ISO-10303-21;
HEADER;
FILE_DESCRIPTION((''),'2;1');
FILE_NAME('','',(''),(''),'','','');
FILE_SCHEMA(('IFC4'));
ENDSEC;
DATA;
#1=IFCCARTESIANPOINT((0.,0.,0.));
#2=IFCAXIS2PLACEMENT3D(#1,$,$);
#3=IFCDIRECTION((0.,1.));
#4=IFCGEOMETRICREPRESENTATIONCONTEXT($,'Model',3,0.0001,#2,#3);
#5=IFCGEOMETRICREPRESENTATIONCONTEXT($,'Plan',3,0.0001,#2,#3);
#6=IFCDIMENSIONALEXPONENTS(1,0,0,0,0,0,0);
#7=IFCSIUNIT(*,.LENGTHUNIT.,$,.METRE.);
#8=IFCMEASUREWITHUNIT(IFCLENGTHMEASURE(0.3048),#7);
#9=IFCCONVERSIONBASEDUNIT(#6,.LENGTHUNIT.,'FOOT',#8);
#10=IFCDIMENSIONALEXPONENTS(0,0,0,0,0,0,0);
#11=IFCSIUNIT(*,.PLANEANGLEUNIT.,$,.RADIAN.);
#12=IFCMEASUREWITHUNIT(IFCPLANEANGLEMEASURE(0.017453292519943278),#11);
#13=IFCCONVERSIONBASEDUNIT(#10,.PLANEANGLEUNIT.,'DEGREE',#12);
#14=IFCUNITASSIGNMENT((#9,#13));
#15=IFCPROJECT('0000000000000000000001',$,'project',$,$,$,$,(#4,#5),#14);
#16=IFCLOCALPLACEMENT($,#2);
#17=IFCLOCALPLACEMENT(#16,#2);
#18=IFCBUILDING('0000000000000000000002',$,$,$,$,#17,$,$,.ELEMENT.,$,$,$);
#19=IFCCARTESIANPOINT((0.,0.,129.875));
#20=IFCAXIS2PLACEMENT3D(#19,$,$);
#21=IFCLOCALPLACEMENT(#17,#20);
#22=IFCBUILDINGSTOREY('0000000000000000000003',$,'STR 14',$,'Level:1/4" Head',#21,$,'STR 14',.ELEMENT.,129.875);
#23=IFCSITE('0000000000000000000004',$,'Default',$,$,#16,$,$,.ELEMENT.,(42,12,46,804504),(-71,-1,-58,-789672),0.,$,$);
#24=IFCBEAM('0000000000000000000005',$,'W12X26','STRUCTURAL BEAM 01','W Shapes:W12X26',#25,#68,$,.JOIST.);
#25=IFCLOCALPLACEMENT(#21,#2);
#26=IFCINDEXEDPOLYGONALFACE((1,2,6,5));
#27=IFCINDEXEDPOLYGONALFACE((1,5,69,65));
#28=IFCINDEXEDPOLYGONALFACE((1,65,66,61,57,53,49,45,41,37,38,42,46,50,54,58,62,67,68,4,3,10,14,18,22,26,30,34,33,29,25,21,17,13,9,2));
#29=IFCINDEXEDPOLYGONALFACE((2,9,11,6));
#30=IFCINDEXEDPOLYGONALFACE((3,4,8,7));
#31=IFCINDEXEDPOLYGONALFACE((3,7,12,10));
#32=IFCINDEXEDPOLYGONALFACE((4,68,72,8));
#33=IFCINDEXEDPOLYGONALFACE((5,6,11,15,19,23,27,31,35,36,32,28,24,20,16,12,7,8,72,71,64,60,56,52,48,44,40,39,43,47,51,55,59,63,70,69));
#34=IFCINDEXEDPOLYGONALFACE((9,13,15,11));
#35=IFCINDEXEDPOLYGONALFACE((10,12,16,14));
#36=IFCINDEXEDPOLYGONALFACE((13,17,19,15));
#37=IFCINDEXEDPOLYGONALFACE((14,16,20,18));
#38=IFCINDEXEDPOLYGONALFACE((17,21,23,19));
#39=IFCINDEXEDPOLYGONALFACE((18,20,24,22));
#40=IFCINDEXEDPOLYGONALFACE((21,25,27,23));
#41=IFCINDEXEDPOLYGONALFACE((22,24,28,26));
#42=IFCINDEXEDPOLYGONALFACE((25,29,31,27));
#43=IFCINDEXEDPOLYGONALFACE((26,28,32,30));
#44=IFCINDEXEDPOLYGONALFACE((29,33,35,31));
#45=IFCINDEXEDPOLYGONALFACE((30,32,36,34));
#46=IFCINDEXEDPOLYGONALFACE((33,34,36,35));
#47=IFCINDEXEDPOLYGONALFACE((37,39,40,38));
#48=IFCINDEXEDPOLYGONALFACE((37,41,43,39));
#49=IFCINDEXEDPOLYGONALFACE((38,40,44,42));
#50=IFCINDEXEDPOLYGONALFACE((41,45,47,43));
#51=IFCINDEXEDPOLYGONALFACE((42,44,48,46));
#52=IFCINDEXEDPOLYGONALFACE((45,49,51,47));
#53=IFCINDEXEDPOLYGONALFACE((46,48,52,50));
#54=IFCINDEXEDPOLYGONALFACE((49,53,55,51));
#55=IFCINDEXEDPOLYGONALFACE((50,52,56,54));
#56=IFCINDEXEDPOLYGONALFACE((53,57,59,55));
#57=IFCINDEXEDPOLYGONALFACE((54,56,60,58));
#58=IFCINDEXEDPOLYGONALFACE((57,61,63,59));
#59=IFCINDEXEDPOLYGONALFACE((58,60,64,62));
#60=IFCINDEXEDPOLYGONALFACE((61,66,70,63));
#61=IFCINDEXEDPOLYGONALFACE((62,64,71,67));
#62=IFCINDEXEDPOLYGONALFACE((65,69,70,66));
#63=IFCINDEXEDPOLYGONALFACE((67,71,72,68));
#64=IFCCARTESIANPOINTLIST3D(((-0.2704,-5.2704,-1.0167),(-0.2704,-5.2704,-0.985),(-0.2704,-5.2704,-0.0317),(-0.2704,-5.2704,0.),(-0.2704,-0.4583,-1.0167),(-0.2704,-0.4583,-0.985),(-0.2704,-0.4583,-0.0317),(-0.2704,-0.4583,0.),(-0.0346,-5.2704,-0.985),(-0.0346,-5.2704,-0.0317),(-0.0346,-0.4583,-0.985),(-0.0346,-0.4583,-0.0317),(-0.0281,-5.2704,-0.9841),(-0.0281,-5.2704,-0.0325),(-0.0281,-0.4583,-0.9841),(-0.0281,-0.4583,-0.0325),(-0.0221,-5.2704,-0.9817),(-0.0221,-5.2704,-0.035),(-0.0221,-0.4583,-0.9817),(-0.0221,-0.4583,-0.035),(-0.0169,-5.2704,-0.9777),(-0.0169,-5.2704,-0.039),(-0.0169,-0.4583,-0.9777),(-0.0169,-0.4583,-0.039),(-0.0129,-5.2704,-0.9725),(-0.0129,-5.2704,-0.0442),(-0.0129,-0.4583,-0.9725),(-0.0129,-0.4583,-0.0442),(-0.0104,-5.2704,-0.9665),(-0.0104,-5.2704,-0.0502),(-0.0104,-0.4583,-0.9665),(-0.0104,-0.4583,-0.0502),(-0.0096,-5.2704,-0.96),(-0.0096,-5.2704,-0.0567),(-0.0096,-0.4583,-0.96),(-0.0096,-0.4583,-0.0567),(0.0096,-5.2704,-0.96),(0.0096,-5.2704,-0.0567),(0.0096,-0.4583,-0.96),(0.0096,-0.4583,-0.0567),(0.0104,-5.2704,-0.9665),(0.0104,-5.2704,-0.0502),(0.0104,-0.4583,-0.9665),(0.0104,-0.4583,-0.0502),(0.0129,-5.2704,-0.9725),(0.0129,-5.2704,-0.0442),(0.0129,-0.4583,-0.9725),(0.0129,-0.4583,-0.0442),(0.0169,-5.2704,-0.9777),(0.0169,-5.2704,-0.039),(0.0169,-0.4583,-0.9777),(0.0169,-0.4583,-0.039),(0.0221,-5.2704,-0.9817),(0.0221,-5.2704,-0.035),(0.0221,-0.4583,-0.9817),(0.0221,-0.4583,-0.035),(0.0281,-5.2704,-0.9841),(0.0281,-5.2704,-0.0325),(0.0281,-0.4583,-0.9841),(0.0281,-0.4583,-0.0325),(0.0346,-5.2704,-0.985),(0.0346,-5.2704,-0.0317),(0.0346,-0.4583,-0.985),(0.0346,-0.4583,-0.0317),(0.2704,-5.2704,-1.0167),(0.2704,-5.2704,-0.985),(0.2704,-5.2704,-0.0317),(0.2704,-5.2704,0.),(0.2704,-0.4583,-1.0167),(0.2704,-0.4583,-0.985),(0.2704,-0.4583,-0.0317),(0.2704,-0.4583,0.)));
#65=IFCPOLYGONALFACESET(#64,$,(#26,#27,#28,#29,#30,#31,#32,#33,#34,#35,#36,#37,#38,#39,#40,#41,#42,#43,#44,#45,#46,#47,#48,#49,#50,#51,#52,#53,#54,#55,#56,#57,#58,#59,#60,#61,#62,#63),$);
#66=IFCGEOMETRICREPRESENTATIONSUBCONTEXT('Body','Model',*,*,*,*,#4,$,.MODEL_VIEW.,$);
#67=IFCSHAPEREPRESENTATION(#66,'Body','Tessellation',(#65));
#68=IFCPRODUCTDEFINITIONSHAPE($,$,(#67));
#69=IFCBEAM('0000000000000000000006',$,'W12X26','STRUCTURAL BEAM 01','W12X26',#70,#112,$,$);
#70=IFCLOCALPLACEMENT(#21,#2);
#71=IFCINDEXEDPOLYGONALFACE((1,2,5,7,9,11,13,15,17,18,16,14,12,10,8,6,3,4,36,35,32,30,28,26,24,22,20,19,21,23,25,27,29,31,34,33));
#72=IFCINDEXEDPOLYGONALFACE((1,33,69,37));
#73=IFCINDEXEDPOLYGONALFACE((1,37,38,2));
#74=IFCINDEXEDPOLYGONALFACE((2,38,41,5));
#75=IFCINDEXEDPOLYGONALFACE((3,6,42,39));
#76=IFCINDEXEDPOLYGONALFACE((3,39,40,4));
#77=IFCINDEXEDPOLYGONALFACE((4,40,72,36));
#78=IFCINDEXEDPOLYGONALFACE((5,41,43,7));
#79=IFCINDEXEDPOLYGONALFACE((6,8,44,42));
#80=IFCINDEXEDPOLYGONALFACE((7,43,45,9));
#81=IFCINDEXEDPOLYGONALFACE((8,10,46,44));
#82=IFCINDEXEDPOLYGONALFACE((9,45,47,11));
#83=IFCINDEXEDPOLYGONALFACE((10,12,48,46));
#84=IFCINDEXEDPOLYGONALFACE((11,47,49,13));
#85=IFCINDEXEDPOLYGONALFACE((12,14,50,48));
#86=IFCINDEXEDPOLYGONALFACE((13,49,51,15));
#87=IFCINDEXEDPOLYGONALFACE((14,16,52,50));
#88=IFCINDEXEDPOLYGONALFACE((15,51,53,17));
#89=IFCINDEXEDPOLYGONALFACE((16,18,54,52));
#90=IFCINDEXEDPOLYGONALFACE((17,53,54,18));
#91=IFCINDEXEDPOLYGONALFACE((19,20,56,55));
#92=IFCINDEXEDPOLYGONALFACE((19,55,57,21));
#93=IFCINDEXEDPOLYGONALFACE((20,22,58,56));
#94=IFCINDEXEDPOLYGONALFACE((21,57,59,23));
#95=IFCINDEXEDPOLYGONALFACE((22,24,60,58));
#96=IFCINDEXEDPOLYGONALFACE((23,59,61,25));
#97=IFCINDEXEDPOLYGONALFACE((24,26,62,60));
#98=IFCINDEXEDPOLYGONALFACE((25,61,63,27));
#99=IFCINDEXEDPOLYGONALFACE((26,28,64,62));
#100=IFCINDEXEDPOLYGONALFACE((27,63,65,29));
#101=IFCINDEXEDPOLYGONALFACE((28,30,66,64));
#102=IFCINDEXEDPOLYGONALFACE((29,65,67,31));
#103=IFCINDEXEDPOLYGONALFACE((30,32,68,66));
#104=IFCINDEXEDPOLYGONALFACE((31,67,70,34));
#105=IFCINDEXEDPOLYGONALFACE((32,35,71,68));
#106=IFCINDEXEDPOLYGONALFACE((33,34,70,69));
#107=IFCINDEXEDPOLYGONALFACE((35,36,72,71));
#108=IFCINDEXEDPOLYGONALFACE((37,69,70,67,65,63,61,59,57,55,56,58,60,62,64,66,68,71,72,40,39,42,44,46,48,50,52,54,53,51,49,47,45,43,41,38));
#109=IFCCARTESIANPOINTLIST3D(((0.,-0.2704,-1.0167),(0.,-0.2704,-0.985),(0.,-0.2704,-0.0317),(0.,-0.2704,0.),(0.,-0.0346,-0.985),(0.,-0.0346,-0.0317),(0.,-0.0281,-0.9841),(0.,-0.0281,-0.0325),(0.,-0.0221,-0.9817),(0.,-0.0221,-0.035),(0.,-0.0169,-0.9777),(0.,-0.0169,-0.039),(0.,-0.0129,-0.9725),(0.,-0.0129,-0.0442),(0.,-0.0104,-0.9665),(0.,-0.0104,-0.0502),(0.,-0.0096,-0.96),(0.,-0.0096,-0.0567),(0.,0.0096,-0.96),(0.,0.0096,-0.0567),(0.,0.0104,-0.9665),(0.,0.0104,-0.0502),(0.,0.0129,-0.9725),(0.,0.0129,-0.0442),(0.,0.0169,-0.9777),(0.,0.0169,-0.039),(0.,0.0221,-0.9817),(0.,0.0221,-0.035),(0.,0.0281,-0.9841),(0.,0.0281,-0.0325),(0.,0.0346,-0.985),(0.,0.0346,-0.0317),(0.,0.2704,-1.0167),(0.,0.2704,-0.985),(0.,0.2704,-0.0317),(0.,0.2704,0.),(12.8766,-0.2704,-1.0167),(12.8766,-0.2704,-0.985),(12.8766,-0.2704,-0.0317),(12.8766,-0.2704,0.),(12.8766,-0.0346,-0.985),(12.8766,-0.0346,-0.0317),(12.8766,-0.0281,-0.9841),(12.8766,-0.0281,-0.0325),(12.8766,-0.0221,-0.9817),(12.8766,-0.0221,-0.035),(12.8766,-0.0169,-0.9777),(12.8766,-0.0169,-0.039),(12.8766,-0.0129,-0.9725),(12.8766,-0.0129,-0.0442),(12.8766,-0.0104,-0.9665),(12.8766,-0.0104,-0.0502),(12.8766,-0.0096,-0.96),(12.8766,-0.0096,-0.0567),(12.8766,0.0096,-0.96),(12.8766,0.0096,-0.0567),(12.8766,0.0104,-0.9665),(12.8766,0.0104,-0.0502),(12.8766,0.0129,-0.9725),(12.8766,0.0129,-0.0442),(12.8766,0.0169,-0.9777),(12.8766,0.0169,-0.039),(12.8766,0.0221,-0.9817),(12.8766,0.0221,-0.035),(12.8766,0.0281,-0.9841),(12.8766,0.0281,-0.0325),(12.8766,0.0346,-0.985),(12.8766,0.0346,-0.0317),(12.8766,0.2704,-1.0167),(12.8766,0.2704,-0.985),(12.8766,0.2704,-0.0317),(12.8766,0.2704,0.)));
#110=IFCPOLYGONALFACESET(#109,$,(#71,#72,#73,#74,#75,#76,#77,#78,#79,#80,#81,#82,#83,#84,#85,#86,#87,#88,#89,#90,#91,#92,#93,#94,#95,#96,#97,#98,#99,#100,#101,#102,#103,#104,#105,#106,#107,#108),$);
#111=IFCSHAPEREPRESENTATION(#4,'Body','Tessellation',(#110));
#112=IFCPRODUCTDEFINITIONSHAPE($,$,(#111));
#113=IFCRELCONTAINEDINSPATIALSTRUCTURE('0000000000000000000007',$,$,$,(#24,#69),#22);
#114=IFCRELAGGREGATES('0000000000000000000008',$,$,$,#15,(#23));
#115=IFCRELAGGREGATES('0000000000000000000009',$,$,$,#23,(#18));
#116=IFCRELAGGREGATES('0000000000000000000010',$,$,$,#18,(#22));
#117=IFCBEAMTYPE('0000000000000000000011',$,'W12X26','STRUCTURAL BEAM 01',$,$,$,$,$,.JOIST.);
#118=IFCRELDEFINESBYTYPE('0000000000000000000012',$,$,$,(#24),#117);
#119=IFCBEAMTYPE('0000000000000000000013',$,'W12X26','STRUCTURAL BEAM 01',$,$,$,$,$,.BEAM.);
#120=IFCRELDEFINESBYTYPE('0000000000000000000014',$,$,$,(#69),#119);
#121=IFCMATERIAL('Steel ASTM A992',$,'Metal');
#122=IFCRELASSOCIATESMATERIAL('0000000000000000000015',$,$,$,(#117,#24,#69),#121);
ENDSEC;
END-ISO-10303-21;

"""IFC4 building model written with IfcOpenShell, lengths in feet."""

from ifc_helpers import new_model, entity, si_unit, converted_unit, direction, frame, origin, origin_2d, place, context, subcontext, project, spatial, line, arc, indexed_curve, i_section, outline, extrude, source, transform, mapped, material, type_object, type_shapes, element, save


model = new_model("IFC4")

# Units and contexts
model_context = context("Model", 3, precision=0.0001, world=origin(), true_north=direction((0.0, 1.0)))
plan_context = context("Plan", 3, precision=0.0001, world=origin(), true_north=direction((0.0, 1.0)))
body_context = subcontext(model_context, "Body", "Model", "MODEL_VIEW")
ifc_project = project(units=[converted_unit("LENGTHUNIT", "FOOT", entity("IfcLengthMeasure", 0.3048), si_unit("LENGTHUNIT", "METRE"), dimensions=[1, 0, 0, 0, 0, 0, 0]), converted_unit("PLANEANGLEUNIT", "DEGREE", entity("IfcPlaneAngleMeasure", 0.017453292519943278), si_unit("PLANEANGLEUNIT", "RADIAN"), dimensions=[0, 0, 0, 0, 0, 0, 0])], contexts=[model_context, plan_context])

# Site, building, storey
site_placement = place(None, origin())
site = spatial("IfcSite", under=ifc_project, at=site_placement, Name="Default", CompositionType="ELEMENT", RefLatitude=(42, 12, 46, 804504), RefLongitude=(-71, -1, -58, -789672), RefElevation=0.0)
building_placement = place(site_placement, origin())
building = spatial("IfcBuilding", under=site, at=building_placement, CompositionType="ELEMENT")
storey_placement = place(building_placement, frame((0.0, 0.0, 129.875)))
storey = spatial("IfcBuildingStorey", under=building, at=storey_placement, Name="STR 14", ObjectType="Level:1/4\" Head", LongName="STR 14", CompositionType="ELEMENT", Elevation=129.875)

# Shared definitions
ifc_material = material(Name="Steel ASTM A992", Category="Metal")

# Beams
beam_type_1 = type_object("IfcBeamType", Name="W12X26", Description="STRUCTURAL BEAM 01", PredefinedType="JOIST", material=ifc_material)
shared_shape_1 = source(origin(), body_context, "Body", "SweptSolid", [
    extrude(outline(indexed_curve([(-0.2704, -0.5083), (0.2704, -0.5083), (0.2704, -0.4767), (0.0346, -0.4767), (0.0169, -0.4693), (0.0096, -0.4517), (0.0096, 0.4517), (0.0169, 0.4693), (0.0346, 0.4767), (0.2704, 0.4767), (0.2704, 0.5083), (-0.2704, 0.5083), (-0.2704, 0.4767), (-0.0346, 0.4767), (-0.0169, 0.4693), (-0.0096, 0.4517), (-0.0096, -0.4517), (-0.0169, -0.4693), (-0.0346, -0.4767), (-0.2704, -0.4767)], segments=[line(1, 2, 3, 4), arc(4, 5, 6), line(6, 7), arc(7, 8, 9), line(9, 10, 11, 12, 13, 14), arc(14, 15, 16), line(16, 17), arc(17, 18, 19), line(19, 20, 1)], self_intersect=False)), frame((0.0, -0.4583, 129.3667), z_axis=(0.0, -1.0, 0.0), x_axis=(-1.0, 0.0, 0.0)), (0.0, 0.0, 1.0), 4.8121),
])
type_shapes(beam_type_1, [shared_shape_1])
beam_1_placement = place(storey_placement, frame((0.0, 0.0, -129.875)))
element("IfcBeam", 1, at=beam_1_placement, inside=storey, type_object=beam_type_1, material=ifc_material, Name="W12X26", Description="STRUCTURAL BEAM 01", ObjectType="W Shapes:W12X26", PredefinedType="JOIST", context=body_context, shape_type="MappedRepresentation", body=[
    mapped(shared_shape_1, transform((0.0, 0.0, 0.0), scale=1.0)),
])
beam_type_2 = type_object("IfcBeamType", Name="W12X26", Description="STRUCTURAL BEAM 01", PredefinedType="BEAM")
beam_2_placement = place(storey_placement, frame((0.0, 0.0, -0.5083), z_axis=(-1.0, 0.0, 0.0), x_axis=(0.0, -1.0, 0.0)))
element("IfcBeam", 2, at=beam_2_placement, inside=storey, type_object=beam_type_2, material=ifc_material, Name="W12X26", Description="STRUCTURAL BEAM 01", ObjectType="W12X26", context=model_context, shape_type="SweptSolid", body=[
    extrude(i_section(OverallWidth=0.5408, OverallDepth=1.0167, WebThickness=0.0192, FlangeThickness=0.0317, FilletRadius=0.025, at=origin_2d()), origin(), (0.0, 0.0, -1.0), 12.8766),
])

save(model, "model.ifc")
